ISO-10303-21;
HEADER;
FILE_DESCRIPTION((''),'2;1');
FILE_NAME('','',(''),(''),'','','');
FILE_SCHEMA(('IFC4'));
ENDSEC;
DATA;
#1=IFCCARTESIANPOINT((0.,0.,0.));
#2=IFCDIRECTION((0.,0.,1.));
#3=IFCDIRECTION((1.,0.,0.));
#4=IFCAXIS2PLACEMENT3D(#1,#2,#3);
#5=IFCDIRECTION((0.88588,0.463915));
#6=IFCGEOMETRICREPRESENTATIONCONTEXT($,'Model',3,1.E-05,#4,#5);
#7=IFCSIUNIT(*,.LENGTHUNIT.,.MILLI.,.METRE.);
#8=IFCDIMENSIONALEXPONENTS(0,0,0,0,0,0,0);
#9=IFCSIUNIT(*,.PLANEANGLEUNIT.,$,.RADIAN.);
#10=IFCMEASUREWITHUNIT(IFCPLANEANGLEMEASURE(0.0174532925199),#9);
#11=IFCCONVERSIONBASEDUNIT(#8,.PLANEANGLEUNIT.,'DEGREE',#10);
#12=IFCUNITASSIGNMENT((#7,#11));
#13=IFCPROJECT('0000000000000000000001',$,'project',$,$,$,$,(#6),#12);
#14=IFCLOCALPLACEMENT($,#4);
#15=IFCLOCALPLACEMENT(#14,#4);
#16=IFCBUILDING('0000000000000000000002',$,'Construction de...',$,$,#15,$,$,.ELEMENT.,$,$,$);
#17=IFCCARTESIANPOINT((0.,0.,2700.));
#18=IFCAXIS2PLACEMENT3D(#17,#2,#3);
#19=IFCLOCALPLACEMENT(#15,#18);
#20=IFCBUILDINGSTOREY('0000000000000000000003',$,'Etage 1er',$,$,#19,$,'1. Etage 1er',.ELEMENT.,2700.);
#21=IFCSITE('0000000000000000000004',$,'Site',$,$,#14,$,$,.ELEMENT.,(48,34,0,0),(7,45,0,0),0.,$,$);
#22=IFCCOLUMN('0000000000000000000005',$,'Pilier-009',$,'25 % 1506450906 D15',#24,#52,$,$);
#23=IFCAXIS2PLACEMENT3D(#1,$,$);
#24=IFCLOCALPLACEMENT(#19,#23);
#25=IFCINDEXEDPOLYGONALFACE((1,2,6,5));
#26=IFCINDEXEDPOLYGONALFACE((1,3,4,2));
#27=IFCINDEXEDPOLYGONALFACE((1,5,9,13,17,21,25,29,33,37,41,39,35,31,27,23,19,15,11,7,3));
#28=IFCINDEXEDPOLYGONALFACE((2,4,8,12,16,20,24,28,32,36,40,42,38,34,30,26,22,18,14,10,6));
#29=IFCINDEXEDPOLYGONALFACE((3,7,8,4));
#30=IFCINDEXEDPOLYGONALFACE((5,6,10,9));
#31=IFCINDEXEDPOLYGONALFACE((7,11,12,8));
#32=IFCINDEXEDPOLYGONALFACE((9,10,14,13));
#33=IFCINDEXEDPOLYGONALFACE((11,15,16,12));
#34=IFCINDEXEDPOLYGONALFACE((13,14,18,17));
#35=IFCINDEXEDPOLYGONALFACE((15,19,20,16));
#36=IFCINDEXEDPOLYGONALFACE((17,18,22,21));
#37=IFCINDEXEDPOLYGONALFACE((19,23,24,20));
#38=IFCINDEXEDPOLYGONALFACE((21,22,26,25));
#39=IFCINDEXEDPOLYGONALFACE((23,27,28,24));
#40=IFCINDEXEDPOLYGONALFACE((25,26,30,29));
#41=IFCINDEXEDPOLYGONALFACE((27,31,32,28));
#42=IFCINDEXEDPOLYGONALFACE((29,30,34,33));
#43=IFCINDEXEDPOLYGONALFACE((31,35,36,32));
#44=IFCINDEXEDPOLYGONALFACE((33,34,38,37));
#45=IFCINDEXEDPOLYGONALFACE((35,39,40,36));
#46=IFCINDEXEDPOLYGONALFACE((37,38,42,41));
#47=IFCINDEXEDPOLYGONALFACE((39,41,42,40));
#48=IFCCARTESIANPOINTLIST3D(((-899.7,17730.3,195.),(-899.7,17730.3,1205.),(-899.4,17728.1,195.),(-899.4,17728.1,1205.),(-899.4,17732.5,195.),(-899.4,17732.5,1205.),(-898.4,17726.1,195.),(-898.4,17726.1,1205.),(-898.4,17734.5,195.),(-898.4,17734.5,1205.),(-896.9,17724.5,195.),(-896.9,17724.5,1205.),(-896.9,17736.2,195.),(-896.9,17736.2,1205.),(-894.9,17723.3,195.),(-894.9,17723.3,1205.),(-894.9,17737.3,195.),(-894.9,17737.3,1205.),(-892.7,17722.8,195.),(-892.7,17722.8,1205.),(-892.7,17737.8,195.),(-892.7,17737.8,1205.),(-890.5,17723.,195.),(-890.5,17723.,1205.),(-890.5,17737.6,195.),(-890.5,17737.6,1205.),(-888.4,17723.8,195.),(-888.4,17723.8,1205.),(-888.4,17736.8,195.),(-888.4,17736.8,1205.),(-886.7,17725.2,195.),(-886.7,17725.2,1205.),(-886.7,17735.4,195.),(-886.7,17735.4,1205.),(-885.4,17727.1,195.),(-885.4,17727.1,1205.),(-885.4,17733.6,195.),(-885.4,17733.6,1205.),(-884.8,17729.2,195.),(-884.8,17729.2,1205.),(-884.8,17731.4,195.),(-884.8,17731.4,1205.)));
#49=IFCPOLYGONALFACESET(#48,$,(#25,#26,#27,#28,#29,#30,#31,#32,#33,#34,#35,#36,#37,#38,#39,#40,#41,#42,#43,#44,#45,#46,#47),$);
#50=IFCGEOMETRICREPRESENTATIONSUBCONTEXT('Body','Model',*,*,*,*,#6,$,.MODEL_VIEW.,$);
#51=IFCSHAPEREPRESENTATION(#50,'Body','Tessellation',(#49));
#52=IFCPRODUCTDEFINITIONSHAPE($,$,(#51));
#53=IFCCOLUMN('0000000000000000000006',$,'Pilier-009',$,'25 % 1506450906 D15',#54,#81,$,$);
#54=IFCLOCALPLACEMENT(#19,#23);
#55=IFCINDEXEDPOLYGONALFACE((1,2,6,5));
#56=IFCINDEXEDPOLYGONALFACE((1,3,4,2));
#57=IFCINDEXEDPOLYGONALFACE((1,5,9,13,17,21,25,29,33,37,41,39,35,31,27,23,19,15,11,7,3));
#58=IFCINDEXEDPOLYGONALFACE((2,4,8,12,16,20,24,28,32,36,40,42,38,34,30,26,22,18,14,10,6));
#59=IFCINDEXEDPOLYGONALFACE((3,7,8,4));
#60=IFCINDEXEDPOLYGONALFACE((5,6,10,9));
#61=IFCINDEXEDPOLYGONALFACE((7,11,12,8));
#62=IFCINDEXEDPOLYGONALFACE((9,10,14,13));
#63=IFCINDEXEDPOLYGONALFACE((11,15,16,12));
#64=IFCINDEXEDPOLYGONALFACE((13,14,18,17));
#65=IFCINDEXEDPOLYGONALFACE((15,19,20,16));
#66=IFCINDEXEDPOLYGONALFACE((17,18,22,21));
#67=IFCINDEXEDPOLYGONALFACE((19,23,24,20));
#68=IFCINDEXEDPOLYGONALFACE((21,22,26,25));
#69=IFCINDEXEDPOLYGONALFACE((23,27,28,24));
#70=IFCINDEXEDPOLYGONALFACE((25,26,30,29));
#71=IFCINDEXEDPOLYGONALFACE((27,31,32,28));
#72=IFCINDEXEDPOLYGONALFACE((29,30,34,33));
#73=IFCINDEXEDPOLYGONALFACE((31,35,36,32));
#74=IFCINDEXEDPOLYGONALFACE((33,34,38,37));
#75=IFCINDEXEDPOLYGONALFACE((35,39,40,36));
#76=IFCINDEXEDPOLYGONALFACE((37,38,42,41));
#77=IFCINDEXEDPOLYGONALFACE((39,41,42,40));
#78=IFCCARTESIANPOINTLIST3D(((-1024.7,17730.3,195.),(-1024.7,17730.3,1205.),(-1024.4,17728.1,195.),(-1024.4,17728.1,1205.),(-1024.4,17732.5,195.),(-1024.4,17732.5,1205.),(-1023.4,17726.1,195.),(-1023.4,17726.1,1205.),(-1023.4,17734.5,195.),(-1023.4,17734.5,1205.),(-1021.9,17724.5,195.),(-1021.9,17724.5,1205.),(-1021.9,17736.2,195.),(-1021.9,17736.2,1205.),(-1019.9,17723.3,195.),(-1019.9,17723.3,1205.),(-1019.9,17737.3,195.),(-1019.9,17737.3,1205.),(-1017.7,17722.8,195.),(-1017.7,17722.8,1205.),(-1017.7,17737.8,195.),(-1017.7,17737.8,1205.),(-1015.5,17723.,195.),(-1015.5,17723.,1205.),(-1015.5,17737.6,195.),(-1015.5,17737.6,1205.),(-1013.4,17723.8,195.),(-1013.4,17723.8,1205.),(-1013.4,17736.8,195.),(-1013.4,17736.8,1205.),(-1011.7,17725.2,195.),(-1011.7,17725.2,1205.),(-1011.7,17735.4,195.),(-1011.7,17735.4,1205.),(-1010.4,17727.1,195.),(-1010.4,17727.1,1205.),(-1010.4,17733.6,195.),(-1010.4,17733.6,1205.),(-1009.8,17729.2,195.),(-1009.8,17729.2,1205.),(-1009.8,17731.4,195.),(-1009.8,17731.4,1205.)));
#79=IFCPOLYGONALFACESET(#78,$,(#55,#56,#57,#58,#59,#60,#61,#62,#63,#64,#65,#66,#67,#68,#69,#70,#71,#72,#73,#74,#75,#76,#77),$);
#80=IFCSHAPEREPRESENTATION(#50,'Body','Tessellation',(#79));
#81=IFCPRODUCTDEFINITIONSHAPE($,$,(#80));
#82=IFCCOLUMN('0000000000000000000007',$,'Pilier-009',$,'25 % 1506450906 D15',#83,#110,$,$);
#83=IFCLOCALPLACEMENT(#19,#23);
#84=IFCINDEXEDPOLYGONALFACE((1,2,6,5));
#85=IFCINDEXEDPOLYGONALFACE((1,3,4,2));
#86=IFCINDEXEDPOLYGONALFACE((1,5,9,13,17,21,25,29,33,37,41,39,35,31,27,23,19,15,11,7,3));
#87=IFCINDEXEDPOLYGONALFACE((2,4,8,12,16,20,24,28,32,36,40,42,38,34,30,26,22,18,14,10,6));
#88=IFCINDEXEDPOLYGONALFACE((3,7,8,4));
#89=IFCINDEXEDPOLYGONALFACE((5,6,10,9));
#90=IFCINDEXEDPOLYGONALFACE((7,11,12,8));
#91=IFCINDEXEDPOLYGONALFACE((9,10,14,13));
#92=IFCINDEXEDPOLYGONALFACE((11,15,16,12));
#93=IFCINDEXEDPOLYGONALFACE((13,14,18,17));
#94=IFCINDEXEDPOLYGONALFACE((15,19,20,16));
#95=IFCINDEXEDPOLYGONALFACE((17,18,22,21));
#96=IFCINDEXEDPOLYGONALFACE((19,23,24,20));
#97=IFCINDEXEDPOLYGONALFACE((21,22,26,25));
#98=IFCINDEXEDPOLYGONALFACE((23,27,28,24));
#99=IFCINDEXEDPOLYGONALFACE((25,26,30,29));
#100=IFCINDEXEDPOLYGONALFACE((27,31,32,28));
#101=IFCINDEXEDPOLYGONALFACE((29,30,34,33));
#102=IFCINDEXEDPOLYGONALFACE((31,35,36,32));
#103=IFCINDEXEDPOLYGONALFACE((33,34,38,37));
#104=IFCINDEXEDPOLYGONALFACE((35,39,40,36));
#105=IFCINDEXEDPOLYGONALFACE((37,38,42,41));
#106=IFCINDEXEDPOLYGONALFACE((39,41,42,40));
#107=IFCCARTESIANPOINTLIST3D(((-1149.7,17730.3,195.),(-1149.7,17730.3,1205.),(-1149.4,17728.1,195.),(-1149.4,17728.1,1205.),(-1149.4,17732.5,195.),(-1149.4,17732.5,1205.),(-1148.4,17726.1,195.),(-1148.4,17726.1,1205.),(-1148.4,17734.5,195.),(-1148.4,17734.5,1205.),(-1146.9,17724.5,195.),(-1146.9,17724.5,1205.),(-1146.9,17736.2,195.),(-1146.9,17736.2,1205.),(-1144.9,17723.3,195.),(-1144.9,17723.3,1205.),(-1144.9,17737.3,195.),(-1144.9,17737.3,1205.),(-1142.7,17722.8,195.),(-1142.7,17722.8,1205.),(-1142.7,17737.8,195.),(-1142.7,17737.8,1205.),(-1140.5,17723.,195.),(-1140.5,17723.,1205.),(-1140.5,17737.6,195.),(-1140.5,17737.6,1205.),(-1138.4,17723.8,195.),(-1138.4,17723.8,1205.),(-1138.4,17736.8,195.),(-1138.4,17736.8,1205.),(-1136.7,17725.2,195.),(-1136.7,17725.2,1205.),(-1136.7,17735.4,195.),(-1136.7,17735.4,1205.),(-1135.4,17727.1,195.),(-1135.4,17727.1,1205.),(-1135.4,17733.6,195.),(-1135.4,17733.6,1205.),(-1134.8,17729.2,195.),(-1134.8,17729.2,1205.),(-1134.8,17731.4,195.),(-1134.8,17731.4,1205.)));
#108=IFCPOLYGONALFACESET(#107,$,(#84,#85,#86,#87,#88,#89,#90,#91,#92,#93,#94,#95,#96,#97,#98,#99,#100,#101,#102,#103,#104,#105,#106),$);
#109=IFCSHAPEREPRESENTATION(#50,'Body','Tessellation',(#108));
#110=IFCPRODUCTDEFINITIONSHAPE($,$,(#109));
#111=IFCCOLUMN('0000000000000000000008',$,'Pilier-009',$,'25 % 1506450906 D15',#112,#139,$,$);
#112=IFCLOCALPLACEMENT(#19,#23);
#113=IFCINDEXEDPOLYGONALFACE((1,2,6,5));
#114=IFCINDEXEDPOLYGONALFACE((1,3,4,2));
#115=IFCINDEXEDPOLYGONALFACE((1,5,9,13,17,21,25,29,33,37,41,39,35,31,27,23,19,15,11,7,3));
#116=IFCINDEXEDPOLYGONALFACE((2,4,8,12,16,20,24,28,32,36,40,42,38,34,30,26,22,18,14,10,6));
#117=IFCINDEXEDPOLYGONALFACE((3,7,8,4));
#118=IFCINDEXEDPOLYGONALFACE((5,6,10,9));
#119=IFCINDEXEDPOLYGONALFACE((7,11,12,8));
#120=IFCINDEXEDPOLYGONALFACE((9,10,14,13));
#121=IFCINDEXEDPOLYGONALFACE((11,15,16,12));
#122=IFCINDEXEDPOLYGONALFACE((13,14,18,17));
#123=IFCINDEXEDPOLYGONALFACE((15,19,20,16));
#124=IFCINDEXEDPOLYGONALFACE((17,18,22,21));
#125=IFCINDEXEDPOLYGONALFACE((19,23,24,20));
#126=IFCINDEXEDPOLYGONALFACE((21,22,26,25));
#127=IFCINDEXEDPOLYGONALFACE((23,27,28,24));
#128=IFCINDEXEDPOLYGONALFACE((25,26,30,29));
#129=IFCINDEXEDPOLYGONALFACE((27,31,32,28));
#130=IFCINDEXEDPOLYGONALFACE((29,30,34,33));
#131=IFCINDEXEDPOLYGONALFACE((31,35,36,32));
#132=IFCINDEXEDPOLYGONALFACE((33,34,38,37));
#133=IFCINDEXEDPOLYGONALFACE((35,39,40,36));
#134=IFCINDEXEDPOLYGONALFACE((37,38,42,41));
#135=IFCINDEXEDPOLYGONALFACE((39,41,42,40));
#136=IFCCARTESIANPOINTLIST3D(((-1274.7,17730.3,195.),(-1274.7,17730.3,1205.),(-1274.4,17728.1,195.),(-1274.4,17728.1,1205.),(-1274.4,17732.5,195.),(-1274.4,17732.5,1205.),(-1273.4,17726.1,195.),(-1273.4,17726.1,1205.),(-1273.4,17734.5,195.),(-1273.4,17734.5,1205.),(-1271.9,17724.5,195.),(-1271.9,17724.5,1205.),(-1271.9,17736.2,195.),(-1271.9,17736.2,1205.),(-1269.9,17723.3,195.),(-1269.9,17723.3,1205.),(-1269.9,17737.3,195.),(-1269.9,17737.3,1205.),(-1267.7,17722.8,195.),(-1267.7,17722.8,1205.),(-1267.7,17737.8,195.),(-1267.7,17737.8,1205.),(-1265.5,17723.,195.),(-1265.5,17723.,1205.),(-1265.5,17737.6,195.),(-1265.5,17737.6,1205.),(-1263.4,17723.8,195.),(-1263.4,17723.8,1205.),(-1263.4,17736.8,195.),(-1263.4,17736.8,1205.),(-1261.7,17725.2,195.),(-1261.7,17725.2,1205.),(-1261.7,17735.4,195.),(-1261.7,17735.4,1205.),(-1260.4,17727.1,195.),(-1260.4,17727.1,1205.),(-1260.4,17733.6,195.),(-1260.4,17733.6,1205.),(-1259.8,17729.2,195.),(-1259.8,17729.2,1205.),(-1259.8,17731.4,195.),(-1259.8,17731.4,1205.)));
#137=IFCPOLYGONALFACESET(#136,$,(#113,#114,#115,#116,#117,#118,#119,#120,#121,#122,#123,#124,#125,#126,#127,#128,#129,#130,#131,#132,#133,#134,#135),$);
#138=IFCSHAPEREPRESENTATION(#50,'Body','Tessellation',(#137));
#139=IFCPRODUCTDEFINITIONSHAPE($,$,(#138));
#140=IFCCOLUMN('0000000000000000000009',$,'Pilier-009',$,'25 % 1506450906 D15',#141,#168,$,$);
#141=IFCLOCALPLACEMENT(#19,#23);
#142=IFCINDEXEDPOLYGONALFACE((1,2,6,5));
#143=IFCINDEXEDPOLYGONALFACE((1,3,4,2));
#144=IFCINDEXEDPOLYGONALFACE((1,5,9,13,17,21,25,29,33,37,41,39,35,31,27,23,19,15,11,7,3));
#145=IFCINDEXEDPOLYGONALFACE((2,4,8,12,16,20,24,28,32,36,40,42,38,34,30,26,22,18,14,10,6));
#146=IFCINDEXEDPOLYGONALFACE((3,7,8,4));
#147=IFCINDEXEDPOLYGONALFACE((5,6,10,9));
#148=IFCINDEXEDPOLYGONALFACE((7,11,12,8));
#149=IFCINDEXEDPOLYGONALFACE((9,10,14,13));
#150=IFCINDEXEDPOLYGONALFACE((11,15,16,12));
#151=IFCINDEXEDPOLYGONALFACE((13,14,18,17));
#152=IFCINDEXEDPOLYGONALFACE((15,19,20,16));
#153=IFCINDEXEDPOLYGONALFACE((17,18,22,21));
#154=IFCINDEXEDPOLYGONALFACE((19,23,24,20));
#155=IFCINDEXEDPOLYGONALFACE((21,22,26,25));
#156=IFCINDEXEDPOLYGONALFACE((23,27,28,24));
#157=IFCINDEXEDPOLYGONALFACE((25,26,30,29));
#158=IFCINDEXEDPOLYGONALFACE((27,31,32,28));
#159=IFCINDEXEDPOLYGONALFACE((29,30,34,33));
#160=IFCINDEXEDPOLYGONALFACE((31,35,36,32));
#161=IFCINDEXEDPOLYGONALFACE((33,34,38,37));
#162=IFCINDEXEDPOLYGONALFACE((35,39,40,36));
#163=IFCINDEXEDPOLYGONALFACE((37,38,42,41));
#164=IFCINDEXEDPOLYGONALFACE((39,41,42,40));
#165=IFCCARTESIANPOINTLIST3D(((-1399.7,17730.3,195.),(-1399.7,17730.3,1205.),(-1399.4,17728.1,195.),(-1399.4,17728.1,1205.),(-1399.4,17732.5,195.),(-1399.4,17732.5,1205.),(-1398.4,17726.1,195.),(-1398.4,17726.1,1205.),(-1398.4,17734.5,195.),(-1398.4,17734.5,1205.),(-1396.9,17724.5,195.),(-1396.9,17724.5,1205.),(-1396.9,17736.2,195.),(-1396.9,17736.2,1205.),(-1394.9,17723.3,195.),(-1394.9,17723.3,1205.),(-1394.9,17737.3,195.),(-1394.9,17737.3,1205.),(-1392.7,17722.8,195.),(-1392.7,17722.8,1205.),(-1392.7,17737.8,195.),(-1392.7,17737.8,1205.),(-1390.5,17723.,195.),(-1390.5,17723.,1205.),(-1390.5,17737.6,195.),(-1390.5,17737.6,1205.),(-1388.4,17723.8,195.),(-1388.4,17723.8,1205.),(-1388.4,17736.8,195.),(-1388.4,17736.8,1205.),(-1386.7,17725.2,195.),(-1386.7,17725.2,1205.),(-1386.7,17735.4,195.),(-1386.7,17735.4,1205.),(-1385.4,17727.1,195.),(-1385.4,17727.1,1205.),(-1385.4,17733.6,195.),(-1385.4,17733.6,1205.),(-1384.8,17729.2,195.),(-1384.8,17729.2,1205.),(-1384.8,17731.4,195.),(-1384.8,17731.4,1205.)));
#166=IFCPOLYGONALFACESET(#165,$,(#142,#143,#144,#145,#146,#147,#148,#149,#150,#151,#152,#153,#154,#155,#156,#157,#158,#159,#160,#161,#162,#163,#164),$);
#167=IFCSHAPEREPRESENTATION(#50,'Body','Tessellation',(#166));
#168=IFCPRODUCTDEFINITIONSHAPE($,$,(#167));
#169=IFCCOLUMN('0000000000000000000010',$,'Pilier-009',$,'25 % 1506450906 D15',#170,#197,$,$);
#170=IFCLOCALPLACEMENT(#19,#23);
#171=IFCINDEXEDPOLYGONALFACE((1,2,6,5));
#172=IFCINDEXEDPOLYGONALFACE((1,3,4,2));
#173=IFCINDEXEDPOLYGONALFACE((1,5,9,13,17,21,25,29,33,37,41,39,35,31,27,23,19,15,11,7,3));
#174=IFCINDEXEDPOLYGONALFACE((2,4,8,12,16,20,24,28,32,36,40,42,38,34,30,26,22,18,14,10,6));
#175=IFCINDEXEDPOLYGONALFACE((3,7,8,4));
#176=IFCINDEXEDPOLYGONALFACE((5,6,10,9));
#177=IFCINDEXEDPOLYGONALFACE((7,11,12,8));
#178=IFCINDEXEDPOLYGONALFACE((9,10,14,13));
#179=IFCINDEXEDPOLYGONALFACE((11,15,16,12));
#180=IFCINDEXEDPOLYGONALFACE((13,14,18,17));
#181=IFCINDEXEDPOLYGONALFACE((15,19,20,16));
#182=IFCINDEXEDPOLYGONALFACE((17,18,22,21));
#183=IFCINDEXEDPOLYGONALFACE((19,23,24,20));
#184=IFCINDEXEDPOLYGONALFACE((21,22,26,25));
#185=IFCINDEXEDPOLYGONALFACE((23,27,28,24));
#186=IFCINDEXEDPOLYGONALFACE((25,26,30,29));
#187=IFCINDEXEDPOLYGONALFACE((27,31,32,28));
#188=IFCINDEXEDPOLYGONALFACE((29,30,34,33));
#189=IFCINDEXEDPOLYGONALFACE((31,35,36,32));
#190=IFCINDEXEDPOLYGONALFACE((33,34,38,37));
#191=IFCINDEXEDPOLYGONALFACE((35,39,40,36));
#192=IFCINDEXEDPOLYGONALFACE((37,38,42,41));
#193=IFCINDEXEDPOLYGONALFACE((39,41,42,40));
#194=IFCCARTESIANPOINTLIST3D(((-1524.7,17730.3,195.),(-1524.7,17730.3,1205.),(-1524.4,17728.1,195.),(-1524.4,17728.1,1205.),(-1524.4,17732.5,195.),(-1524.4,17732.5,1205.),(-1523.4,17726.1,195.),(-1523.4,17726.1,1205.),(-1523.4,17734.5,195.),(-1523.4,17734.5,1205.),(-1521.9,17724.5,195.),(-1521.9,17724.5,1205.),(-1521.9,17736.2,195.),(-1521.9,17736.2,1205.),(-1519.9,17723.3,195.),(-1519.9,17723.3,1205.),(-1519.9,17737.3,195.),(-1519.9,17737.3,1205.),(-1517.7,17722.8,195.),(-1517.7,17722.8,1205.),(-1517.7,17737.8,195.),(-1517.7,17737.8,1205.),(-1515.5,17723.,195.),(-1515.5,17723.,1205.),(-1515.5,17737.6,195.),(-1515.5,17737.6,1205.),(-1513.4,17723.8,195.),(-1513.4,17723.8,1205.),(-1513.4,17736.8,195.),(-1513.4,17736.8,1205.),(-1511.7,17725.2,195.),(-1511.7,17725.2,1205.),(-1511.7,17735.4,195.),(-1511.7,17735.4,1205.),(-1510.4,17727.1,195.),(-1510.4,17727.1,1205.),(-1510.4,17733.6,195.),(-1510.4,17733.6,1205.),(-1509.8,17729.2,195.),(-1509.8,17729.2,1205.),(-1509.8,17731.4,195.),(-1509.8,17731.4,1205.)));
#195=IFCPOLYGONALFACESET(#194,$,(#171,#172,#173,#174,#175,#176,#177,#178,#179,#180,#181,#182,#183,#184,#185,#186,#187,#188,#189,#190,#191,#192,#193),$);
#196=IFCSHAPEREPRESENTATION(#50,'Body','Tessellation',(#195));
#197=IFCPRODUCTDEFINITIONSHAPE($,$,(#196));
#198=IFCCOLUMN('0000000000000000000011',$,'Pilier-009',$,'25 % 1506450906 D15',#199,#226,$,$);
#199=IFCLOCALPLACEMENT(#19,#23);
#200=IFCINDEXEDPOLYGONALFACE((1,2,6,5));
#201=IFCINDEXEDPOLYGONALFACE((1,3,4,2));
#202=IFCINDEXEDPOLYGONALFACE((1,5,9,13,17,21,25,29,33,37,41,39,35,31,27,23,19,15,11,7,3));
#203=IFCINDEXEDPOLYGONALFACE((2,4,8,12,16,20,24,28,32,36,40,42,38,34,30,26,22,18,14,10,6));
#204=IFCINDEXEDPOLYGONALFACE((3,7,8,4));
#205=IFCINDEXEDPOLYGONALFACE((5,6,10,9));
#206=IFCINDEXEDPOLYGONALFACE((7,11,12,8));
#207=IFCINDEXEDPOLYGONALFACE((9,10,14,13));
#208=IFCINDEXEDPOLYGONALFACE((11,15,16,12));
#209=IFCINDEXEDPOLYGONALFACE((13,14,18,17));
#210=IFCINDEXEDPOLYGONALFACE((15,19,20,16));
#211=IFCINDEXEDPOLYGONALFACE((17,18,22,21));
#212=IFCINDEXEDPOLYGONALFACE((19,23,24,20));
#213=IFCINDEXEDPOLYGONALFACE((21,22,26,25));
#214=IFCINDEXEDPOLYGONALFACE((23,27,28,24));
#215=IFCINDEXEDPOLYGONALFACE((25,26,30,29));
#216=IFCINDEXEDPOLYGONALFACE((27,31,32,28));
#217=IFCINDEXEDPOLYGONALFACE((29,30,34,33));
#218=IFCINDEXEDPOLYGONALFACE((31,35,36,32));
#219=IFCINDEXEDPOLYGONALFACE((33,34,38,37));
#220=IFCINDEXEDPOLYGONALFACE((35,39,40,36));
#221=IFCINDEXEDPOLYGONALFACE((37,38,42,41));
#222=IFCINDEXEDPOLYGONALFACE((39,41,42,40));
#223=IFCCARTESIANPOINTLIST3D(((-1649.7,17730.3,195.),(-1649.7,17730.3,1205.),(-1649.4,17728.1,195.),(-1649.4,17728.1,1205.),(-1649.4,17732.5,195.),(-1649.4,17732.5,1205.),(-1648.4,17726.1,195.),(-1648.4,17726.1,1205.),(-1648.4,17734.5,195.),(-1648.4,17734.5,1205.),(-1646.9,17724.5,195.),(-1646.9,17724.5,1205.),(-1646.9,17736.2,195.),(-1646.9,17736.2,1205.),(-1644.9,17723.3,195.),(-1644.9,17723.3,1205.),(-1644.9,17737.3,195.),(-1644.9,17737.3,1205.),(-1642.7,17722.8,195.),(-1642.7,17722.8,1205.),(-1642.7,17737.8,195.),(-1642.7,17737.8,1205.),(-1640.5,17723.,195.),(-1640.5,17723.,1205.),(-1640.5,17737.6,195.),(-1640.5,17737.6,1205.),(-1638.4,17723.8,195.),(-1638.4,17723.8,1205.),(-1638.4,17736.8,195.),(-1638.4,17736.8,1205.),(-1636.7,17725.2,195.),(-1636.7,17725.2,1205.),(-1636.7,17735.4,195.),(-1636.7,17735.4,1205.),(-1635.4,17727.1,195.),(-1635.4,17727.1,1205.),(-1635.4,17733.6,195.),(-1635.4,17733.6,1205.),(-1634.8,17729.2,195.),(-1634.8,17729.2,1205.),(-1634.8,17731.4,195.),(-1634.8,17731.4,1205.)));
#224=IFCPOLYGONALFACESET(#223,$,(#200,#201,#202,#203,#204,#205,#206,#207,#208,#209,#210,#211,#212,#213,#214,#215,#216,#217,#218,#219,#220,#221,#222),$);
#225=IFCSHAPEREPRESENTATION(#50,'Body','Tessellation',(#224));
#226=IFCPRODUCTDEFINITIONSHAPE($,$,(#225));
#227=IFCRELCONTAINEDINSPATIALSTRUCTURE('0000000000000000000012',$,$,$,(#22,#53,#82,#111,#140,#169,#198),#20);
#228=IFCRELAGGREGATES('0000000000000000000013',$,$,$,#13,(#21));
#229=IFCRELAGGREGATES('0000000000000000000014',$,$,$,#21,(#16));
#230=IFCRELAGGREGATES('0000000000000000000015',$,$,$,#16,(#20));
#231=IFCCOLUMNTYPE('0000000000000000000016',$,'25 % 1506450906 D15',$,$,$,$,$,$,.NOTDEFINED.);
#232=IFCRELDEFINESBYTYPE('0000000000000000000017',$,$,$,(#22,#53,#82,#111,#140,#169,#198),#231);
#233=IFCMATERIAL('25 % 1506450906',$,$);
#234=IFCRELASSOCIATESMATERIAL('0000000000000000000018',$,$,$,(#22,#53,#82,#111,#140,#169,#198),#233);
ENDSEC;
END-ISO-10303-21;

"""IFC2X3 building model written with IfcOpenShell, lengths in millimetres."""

from ifc_helpers import new_model, entity, si_unit, converted_unit, direction, frame, origin_with_axes, origin_2d_with_axis, place, context, subcontext, project, spatial, circle, extrude, material, type_object, element, save


model = new_model("IFC2X3")

# Units and contexts
model_context = context("Model", 3, precision=1e-05, world=origin_with_axes(), true_north=direction((0.88588, 0.463915)))
body_context = subcontext(model_context, "Body", "Model", "MODEL_VIEW")
ifc_project = project(units=[si_unit("LENGTHUNIT", "METRE", prefix="MILLI"), converted_unit("PLANEANGLEUNIT", "DEGREE", entity("IfcPlaneAngleMeasure", 0.0174532925199), si_unit("PLANEANGLEUNIT", "RADIAN"), dimensions=[0, 0, 0, 0, 0, 0, 0])], contexts=[model_context])

# Site, building, storey
site_placement = place(None, origin_with_axes())
site = spatial("IfcSite", under=ifc_project, at=site_placement, Name="Site", CompositionType="ELEMENT", RefLatitude=(48, 34, 0, 0), RefLongitude=(7, 45, 0, 0), RefElevation=0.0)
building_placement = place(site_placement, origin_with_axes())
building = spatial("IfcBuilding", under=site, at=building_placement, Name="Construction de...", CompositionType="ELEMENT")
storey_placement = place(building_placement, frame((0.0, 0.0, 2700.0), z_axis=(0.0, 0.0, 1.0), x_axis=(1.0, 0.0, 0.0)))
storey = spatial("IfcBuildingStorey", under=building, at=storey_placement, Name="Etage 1er", LongName="1. Etage 1er", CompositionType="ELEMENT", Elevation=2700.0)

# Columns
ifc_material_1 = material(Name="25 % 1506450906")
column_type = type_object("IfcColumnType", Name="25 % 1506450906 D15", PredefinedType="NOTDEFINED")
for number, where, z_axis, x_axis, name in (
    (1, (-892.2, 17730.3, 195.0), (0.0, 0.0, 1.0), (-1.0, 0.0, 0.0), "Pilier-009"),
    (2, (-1017.2, 17730.3, 195.0), (0.0, 0.0, 1.0), (-1.0, 0.0, 0.0), "Pilier-009"),
    (3, (-1142.2, 17730.3, 195.0), (0.0, 0.0, 1.0), (-1.0, 0.0, 0.0), "Pilier-009"),
    (4, (-1267.2, 17730.3, 195.0), (0.0, 0.0, 1.0), (-1.0, 0.0, 0.0), "Pilier-009"),
    (5, (-1392.2, 17730.3, 195.0), (0.0, 0.0, 1.0), (-1.0, 0.0, 0.0), "Pilier-009"),
    (6, (-1517.2, 17730.3, 195.0), (0.0, 0.0, 1.0), (-1.0, 0.0, 0.0), "Pilier-009"),
    (7, (-1642.2, 17730.3, 195.0), (0.0, 0.0, 1.0), (-1.0, 0.0, 0.0), "Pilier-009"),
):
    element("IfcColumn", number, at=place(storey_placement, frame(where, z_axis=z_axis, x_axis=x_axis)), inside=storey, type_object=column_type, material=ifc_material_1, Name=name, ObjectType="25 % 1506450906 D15", context=body_context, shape_type="SweptSolid", body=[
        extrude(circle(Radius=7.5, at=origin_2d_with_axis()), origin_with_axes(), (0.0, 0.0, 1.0), 1010.0),
    ])

save(model, "model.ifc")
